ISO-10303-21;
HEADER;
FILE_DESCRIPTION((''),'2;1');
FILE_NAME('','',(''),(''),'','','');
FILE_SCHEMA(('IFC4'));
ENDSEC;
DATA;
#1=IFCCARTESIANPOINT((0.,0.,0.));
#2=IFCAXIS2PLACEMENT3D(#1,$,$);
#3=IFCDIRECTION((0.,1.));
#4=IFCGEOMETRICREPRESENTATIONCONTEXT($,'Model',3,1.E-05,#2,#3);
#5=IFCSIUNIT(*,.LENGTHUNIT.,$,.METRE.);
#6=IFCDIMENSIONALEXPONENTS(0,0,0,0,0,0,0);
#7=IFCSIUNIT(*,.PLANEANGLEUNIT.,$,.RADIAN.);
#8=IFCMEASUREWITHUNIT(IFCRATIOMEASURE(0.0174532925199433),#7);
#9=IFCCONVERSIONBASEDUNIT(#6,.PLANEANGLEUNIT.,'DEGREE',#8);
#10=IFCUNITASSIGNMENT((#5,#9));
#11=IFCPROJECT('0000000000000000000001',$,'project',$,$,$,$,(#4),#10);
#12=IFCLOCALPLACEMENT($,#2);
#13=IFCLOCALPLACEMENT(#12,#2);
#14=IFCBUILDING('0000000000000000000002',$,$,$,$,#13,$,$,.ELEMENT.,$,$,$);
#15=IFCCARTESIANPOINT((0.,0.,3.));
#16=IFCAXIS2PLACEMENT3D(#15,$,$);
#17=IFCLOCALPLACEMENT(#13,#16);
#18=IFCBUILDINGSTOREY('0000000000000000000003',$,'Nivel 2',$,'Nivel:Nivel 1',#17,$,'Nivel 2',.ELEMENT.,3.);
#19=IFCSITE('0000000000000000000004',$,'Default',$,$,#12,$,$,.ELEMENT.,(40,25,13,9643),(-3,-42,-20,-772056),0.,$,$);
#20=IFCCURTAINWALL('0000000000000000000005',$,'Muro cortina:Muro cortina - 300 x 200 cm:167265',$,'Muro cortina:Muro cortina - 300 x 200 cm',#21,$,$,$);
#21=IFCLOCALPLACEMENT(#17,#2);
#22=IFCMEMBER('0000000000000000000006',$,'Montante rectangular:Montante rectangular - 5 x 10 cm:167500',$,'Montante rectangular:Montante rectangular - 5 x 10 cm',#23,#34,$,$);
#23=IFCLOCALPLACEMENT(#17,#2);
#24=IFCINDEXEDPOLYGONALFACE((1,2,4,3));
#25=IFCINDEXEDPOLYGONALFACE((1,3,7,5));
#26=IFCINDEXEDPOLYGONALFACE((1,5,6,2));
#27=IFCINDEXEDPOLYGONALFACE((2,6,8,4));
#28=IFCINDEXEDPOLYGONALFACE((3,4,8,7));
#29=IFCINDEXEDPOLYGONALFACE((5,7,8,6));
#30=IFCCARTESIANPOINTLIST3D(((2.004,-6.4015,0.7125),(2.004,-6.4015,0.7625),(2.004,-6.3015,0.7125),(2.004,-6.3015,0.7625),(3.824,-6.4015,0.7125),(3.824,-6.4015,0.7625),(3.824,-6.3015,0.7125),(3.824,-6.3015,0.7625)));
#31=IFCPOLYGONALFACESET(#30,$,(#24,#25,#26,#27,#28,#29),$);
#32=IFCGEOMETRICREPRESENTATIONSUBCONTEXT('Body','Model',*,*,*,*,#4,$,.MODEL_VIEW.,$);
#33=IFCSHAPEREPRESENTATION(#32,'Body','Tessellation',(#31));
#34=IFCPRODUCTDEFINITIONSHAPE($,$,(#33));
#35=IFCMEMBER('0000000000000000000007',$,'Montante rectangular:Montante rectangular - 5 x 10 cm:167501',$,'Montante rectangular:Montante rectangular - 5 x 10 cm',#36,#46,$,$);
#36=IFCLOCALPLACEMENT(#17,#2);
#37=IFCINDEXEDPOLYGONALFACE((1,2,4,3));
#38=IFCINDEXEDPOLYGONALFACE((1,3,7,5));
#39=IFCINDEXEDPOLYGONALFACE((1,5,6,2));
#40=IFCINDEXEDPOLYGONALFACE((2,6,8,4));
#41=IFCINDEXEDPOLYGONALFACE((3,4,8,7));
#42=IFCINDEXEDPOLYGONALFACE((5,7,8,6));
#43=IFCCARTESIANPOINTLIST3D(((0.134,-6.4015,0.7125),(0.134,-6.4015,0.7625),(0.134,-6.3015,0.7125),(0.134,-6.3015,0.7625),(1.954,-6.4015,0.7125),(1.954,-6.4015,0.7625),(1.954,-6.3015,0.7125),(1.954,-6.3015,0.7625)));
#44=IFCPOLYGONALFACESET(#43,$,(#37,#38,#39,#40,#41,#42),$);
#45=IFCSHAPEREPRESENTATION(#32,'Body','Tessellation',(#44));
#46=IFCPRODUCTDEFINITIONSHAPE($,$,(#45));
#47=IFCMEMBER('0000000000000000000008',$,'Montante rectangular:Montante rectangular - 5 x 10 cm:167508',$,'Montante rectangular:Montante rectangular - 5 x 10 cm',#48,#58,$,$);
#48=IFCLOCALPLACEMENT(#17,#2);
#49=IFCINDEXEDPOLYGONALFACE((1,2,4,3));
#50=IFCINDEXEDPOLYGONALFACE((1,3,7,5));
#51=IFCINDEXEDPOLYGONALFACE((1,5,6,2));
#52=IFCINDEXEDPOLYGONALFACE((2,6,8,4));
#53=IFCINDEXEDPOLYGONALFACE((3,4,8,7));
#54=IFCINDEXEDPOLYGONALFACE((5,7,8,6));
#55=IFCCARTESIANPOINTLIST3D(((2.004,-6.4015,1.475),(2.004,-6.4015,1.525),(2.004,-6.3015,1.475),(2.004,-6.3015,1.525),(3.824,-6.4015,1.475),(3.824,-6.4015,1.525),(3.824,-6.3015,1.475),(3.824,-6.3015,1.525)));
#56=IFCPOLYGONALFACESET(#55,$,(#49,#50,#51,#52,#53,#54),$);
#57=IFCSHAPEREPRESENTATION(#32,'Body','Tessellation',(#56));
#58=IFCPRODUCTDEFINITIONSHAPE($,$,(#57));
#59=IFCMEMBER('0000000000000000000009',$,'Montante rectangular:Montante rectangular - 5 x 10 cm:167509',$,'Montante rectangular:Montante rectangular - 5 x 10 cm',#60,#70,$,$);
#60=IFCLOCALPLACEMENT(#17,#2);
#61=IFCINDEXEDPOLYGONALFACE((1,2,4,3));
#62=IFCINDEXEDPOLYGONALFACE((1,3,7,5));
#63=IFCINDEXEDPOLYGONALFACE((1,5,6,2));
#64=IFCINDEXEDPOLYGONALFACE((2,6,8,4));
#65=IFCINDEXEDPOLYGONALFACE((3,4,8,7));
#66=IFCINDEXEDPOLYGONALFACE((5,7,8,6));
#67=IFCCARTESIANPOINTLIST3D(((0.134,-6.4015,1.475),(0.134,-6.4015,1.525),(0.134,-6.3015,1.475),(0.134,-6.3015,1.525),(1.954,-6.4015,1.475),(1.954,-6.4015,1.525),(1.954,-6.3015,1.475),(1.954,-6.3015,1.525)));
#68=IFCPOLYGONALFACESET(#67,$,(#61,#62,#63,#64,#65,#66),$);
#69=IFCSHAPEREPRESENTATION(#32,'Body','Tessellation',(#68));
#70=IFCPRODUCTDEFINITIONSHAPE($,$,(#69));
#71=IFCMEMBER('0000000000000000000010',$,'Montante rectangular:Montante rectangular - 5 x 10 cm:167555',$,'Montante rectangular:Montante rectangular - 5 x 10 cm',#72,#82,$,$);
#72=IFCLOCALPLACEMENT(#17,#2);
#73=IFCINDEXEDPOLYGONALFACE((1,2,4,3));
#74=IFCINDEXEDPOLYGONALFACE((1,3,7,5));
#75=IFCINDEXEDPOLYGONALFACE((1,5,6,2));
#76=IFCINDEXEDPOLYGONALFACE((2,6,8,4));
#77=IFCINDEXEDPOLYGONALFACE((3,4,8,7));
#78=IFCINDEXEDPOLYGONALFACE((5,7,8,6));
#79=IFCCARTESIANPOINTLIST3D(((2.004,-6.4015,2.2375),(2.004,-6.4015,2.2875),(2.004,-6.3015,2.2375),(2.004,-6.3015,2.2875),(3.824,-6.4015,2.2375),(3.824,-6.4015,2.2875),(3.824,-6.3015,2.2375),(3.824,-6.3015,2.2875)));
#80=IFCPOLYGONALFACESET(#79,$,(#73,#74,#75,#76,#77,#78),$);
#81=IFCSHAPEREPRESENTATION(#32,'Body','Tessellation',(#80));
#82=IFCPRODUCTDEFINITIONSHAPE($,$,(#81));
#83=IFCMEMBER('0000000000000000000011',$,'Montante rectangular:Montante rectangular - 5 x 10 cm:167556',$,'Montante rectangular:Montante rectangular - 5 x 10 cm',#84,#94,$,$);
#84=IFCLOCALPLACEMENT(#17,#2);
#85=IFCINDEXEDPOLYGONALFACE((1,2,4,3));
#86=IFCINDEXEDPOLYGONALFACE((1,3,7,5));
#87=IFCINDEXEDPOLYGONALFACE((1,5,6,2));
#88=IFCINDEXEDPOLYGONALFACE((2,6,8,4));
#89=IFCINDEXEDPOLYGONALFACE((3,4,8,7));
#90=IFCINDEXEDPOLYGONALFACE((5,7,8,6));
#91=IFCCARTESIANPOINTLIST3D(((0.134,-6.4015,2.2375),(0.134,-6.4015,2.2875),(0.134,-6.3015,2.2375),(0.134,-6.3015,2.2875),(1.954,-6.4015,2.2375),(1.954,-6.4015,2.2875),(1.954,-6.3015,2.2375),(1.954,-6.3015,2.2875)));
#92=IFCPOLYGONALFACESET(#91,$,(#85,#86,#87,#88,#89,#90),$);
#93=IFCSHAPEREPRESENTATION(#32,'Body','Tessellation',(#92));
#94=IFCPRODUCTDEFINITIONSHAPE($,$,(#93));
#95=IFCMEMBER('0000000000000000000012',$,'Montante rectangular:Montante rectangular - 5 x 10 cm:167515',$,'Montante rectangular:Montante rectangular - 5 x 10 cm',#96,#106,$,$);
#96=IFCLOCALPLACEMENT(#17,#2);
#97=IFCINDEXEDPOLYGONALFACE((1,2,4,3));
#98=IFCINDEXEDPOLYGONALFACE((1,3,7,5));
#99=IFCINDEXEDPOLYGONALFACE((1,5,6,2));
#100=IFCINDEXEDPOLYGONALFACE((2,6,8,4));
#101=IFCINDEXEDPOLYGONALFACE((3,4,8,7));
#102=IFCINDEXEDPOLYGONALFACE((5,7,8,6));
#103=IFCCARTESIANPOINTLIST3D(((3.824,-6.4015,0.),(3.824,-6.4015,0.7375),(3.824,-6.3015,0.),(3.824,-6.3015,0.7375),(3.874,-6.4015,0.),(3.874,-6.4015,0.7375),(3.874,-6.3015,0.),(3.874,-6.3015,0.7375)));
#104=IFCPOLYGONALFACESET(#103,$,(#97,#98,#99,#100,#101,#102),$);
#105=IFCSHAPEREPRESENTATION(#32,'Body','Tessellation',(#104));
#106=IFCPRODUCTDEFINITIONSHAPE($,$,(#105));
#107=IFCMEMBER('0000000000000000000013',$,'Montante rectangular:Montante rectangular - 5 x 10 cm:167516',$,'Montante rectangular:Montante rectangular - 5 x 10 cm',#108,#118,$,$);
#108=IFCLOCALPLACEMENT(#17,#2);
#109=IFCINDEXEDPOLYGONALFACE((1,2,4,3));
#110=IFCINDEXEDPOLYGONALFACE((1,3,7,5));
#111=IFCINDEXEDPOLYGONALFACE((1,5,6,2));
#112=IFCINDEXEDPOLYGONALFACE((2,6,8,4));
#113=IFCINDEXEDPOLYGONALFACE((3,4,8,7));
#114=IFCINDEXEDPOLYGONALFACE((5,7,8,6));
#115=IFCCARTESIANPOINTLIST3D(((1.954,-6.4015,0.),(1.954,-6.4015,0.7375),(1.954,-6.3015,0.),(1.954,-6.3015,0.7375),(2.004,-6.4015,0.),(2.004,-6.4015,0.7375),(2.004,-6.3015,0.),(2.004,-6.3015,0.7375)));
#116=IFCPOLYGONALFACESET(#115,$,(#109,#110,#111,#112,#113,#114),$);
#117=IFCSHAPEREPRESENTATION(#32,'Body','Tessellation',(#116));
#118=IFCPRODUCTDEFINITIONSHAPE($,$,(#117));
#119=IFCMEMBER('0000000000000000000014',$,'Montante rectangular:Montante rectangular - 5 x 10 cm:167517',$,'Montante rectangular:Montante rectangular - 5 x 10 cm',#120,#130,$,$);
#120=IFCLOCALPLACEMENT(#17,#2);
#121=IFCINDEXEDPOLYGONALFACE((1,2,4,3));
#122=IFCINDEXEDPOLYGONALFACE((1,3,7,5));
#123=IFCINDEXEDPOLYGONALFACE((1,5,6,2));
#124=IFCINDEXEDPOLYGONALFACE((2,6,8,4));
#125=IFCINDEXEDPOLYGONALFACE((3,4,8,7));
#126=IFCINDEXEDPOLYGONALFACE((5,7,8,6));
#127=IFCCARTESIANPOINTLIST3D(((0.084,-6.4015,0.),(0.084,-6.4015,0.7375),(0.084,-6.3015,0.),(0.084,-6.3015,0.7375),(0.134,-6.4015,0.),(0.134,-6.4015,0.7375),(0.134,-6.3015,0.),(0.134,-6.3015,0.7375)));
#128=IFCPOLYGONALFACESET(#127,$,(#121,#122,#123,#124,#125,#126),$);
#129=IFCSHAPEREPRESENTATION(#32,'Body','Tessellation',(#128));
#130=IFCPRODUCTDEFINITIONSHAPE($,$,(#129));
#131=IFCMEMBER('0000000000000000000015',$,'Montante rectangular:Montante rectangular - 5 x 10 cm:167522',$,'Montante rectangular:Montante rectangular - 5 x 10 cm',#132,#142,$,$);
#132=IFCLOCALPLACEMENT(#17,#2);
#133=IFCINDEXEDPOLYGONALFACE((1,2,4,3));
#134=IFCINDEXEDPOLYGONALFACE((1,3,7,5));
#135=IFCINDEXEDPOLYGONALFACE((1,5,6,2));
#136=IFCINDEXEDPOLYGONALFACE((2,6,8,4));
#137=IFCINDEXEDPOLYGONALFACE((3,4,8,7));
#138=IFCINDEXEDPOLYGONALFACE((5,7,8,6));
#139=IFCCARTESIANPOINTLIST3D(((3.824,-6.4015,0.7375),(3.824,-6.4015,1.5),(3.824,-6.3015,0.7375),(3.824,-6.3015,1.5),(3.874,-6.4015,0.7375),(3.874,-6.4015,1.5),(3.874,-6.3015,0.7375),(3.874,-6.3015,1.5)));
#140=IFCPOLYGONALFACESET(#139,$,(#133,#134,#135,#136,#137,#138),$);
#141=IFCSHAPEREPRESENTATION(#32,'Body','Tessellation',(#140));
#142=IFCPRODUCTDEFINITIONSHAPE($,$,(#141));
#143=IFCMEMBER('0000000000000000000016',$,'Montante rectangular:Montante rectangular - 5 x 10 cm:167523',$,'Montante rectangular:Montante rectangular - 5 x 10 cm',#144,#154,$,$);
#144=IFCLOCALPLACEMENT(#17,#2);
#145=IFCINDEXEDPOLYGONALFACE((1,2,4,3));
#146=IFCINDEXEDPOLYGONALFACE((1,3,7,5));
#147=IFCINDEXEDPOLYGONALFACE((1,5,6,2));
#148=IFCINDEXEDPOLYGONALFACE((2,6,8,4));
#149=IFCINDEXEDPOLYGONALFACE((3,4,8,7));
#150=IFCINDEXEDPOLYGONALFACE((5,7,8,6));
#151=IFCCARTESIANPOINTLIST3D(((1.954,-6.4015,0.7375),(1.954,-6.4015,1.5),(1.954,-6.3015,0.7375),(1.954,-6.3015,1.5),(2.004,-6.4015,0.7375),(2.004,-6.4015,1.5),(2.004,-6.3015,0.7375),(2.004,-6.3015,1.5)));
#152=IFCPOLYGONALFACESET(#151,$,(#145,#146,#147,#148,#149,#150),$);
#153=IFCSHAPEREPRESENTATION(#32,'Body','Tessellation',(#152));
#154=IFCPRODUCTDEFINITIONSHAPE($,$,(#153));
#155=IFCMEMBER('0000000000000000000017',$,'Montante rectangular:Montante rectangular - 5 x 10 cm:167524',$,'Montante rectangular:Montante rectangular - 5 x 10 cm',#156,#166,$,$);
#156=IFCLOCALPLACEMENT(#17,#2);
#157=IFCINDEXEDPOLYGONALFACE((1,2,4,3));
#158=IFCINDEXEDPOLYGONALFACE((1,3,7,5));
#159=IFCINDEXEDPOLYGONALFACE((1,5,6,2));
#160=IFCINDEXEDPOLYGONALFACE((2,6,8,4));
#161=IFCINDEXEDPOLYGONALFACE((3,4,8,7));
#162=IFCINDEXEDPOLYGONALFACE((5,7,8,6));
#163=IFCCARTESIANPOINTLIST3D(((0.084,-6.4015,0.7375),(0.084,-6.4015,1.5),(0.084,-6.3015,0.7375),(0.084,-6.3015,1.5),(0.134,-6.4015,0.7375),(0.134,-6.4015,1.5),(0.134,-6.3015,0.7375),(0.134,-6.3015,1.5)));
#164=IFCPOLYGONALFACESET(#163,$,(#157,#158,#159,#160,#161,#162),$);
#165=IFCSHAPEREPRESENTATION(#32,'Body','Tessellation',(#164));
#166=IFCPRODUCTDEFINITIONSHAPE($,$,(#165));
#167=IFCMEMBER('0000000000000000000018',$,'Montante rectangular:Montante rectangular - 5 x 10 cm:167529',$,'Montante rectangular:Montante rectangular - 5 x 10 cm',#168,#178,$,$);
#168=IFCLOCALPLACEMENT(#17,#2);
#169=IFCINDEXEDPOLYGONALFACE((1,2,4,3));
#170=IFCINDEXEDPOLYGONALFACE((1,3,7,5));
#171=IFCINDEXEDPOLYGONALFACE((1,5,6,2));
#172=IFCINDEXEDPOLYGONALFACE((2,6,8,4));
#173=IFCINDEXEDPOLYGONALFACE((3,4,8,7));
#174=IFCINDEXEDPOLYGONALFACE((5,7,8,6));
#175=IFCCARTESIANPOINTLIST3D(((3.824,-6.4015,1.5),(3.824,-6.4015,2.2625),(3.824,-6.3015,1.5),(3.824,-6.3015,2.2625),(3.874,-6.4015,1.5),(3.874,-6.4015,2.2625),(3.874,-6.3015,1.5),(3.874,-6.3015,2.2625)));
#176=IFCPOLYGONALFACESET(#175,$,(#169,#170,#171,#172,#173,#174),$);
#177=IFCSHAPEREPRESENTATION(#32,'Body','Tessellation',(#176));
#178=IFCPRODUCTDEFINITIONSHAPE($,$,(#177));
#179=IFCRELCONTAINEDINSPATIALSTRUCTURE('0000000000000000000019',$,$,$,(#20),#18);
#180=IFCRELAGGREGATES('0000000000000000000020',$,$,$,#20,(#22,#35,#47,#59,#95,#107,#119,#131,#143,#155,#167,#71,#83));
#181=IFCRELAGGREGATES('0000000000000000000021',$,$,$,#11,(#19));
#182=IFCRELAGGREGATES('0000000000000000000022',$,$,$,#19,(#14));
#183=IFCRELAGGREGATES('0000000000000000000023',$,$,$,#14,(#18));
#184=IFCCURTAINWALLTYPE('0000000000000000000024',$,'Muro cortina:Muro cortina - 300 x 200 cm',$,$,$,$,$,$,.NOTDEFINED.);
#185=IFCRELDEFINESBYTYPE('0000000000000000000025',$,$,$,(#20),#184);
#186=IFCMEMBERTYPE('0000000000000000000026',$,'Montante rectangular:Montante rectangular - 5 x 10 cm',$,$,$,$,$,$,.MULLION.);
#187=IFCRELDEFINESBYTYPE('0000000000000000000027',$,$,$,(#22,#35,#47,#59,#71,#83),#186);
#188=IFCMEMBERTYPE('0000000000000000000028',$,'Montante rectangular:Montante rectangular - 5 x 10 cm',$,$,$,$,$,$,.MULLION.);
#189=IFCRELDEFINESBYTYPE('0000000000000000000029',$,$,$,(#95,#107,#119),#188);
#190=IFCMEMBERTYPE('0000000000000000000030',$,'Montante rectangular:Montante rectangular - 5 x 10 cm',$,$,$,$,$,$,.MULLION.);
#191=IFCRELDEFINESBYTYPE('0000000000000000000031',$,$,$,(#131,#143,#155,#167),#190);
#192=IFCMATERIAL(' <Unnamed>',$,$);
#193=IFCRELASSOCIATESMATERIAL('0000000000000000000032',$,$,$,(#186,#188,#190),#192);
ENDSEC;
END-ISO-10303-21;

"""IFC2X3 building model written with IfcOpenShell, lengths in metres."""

from ifc_helpers import new_model, entity, si_unit, converted_unit, direction, frame, origin, origin_2d_with_axis, place, context, subcontext, project, spatial, rectangle, extrude, source, transform, mapped, material, type_object, type_shapes, element, aggregate, save


model = new_model("IFC2X3")

# Units and contexts
model_context = context("Model", 3, precision=1e-05, world=origin(), true_north=direction((0.0, 1.0)))
body_context = subcontext(model_context, "Body", "Model", "MODEL_VIEW")
ifc_project = project(units=[si_unit("LENGTHUNIT", "METRE"), converted_unit("PLANEANGLEUNIT", "DEGREE", entity("IfcRatioMeasure", 0.0174532925199433), si_unit("PLANEANGLEUNIT", "RADIAN"), dimensions=[0, 0, 0, 0, 0, 0, 0])], contexts=[model_context])

# Site, building, storey
site_placement = place(None, origin())
site = spatial("IfcSite", under=ifc_project, at=site_placement, Name="Default", CompositionType="ELEMENT", RefLatitude=(40, 25, 13, 9643), RefLongitude=(-3, -42, -20, -772056), RefElevation=0.0)
building_placement = place(site_placement, origin())
building = spatial("IfcBuilding", under=site, at=building_placement, CompositionType="ELEMENT")
storey_placement = place(building_placement, frame((0.0, 0.0, 3.0)))
storey = spatial("IfcBuildingStorey", under=building, at=storey_placement, Name="Nivel 2", ObjectType="Nivel:Nivel 1", LongName="Nivel 2", CompositionType="ELEMENT", Elevation=3.0)

# Curtain wall, members
curtain_wall_type = type_object("IfcCurtainWallType", Name="Muro cortina:Muro cortina - 300 x 200 cm", PredefinedType="NOTDEFINED")
curtain_wall_placement = place(storey_placement, frame((0.0, 0.0, -3.0)))
curtain_wall = element("IfcCurtainWall", 1, at=curtain_wall_placement, inside=storey, type_object=curtain_wall_type, Name="Muro cortina:Muro cortina - 300 x 200 cm:167265", ObjectType="Muro cortina:Muro cortina - 300 x 200 cm")
ifc_material_1 = material(Name=" <Unnamed>")
member_type_1 = type_object("IfcMemberType", Name="Montante rectangular:Montante rectangular - 5 x 10 cm", PredefinedType="MULLION", material=ifc_material_1)
shared_shape_1 = source(origin(), body_context, "Body", "SweptSolid", [
    extrude(rectangle(XDim=0.1, YDim=0.05, at=origin_2d_with_axis()), frame((0.0, 0.0, -1.82), z_axis=(0.0, 0.0, 1.0), x_axis=(0.0, -1.0, 0.0)), (0.0, 0.0, 1.0), 1.82),
])
type_shapes(member_type_1, [shared_shape_1])
member_1_placement = place(storey_placement, frame((2.004, -6.3515, 0.7375), z_axis=(-1.0, 0.0, 0.0), x_axis=(0.0, 0.0, 1.0)))
member_1 = element("IfcMember", 2, at=member_1_placement, type_object=member_type_1, Name="Montante rectangular:Montante rectangular - 5 x 10 cm:167500", ObjectType="Montante rectangular:Montante rectangular - 5 x 10 cm", context=body_context, shape_type="MappedRepresentation", body=[
    mapped(shared_shape_1, transform((0.0, 0.0, 0.0), scale=1.0)),
])
member_2_placement = place(storey_placement, frame((0.134, -6.3515, 0.7375), z_axis=(-1.0, 0.0, 0.0), x_axis=(0.0, 0.0, 1.0)))
member_2 = element("IfcMember", 3, at=member_2_placement, type_object=member_type_1, Name="Montante rectangular:Montante rectangular - 5 x 10 cm:167501", ObjectType="Montante rectangular:Montante rectangular - 5 x 10 cm", context=body_context, shape_type="MappedRepresentation", body=[
    mapped(shared_shape_1, transform((0.0, 0.0, 0.0), scale=1.0)),
])
member_3_placement = place(storey_placement, frame((2.004, -6.3515, 1.5), z_axis=(-1.0, 0.0, 0.0), x_axis=(0.0, 0.0, 1.0)))
member_3 = element("IfcMember", 4, at=member_3_placement, type_object=member_type_1, Name="Montante rectangular:Montante rectangular - 5 x 10 cm:167508", ObjectType="Montante rectangular:Montante rectangular - 5 x 10 cm", context=body_context, shape_type="MappedRepresentation", body=[
    mapped(shared_shape_1, transform((0.0, 0.0, 0.0), scale=1.0)),
])
member_4_placement = place(storey_placement, frame((0.134, -6.3515, 1.5), z_axis=(-1.0, 0.0, 0.0), x_axis=(0.0, 0.0, 1.0)))
member_4 = element("IfcMember", 5, at=member_4_placement, type_object=member_type_1, Name="Montante rectangular:Montante rectangular - 5 x 10 cm:167509", ObjectType="Montante rectangular:Montante rectangular - 5 x 10 cm", context=body_context, shape_type="MappedRepresentation", body=[
    mapped(shared_shape_1, transform((0.0, 0.0, 0.0), scale=1.0)),
])
member_5_placement = place(storey_placement, frame((2.004, -6.3515, 2.2625), z_axis=(-1.0, 0.0, 0.0), x_axis=(0.0, 0.0, 1.0)))
member_5 = element("IfcMember", 6, at=member_5_placement, type_object=member_type_1, Name="Montante rectangular:Montante rectangular - 5 x 10 cm:167555", ObjectType="Montante rectangular:Montante rectangular - 5 x 10 cm", context=body_context, shape_type="MappedRepresentation", body=[
    mapped(shared_shape_1, transform((0.0, 0.0, 0.0), scale=1.0)),
])
member_6_placement = place(storey_placement, frame((0.134, -6.3515, 2.2625), z_axis=(-1.0, 0.0, 0.0), x_axis=(0.0, 0.0, 1.0)))
member_6 = element("IfcMember", 7, at=member_6_placement, type_object=member_type_1, Name="Montante rectangular:Montante rectangular - 5 x 10 cm:167556", ObjectType="Montante rectangular:Montante rectangular - 5 x 10 cm", context=body_context, shape_type="MappedRepresentation", body=[
    mapped(shared_shape_1, transform((0.0, 0.0, 0.0), scale=1.0)),
])
member_type_2 = type_object("IfcMemberType", Name="Montante rectangular:Montante rectangular - 5 x 10 cm", PredefinedType="MULLION", material=ifc_material_1)
shared_shape_2 = source(origin(), body_context, "Body", "SweptSolid", [
    extrude(rectangle(XDim=0.1, YDim=0.05, at=origin_2d_with_axis()), frame((0.0, 0.0, -0.7375), z_axis=(0.0, 0.0, 1.0), x_axis=(0.0, -1.0, 0.0)), (0.0, 0.0, 1.0), 0.7375),
])
type_shapes(member_type_2, [shared_shape_2])
member_7_placement = place(storey_placement, frame((3.849, -6.3515, 0.0), z_axis=(0.0, 0.0, -1.0), x_axis=(-1.0, 0.0, 0.0)))
member_7 = element("IfcMember", 8, at=member_7_placement, type_object=member_type_2, Name="Montante rectangular:Montante rectangular - 5 x 10 cm:167515", ObjectType="Montante rectangular:Montante rectangular - 5 x 10 cm", context=body_context, shape_type="MappedRepresentation", body=[
    mapped(shared_shape_2, transform((0.0, 0.0, 0.0), scale=1.0)),
])
member_8_placement = place(storey_placement, frame((1.979, -6.3515, 0.0), z_axis=(0.0, 0.0, -1.0), x_axis=(-1.0, 0.0, 0.0)))
member_8 = element("IfcMember", 9, at=member_8_placement, type_object=member_type_2, Name="Montante rectangular:Montante rectangular - 5 x 10 cm:167516", ObjectType="Montante rectangular:Montante rectangular - 5 x 10 cm", context=body_context, shape_type="MappedRepresentation", body=[
    mapped(shared_shape_2, transform((0.0, 0.0, 0.0), scale=1.0)),
])
member_9_placement = place(storey_placement, frame((0.109, -6.3515, 0.0), z_axis=(0.0, 0.0, -1.0), x_axis=(-1.0, 0.0, 0.0)))
member_9 = element("IfcMember", 10, at=member_9_placement, type_object=member_type_2, Name="Montante rectangular:Montante rectangular - 5 x 10 cm:167517", ObjectType="Montante rectangular:Montante rectangular - 5 x 10 cm", context=body_context, shape_type="MappedRepresentation", body=[
    mapped(shared_shape_2, transform((0.0, 0.0, 0.0), scale=1.0)),
])
member_type_3 = type_object("IfcMemberType", Name="Montante rectangular:Montante rectangular - 5 x 10 cm", PredefinedType="MULLION", material=ifc_material_1)
shared_shape_3 = source(origin(), body_context, "Body", "SweptSolid", [
    extrude(rectangle(XDim=0.1, YDim=0.05, at=origin_2d_with_axis()), frame((0.0, 0.0, -0.7625), z_axis=(0.0, 0.0, 1.0), x_axis=(0.0, -1.0, 0.0)), (0.0, 0.0, 1.0), 0.7625),
])
type_shapes(member_type_3, [shared_shape_3])
member_10_placement = place(storey_placement, frame((3.849, -6.3515, 0.7375), z_axis=(0.0, 0.0, -1.0), x_axis=(-1.0, 0.0, 0.0)))
member_10 = element("IfcMember", 11, at=member_10_placement, type_object=member_type_3, Name="Montante rectangular:Montante rectangular - 5 x 10 cm:167522", ObjectType="Montante rectangular:Montante rectangular - 5 x 10 cm", context=body_context, shape_type="MappedRepresentation", body=[
    mapped(shared_shape_3, transform((0.0, 0.0, 0.0), scale=1.0)),
])
member_11_placement = place(storey_placement, frame((1.979, -6.3515, 0.7375), z_axis=(0.0, 0.0, -1.0), x_axis=(-1.0, 0.0, 0.0)))
member_11 = element("IfcMember", 12, at=member_11_placement, type_object=member_type_3, Name="Montante rectangular:Montante rectangular - 5 x 10 cm:167523", ObjectType="Montante rectangular:Montante rectangular - 5 x 10 cm", context=body_context, shape_type="MappedRepresentation", body=[
    mapped(shared_shape_3, transform((0.0, 0.0, 0.0), scale=1.0)),
])
member_12_placement = place(storey_placement, frame((0.109, -6.3515, 0.7375), z_axis=(0.0, 0.0, -1.0), x_axis=(-1.0, 0.0, 0.0)))
member_12 = element("IfcMember", 13, at=member_12_placement, type_object=member_type_3, Name="Montante rectangular:Montante rectangular - 5 x 10 cm:167524", ObjectType="Montante rectangular:Montante rectangular - 5 x 10 cm", context=body_context, shape_type="MappedRepresentation", body=[
    mapped(shared_shape_3, transform((0.0, 0.0, 0.0), scale=1.0)),
])
member_13_placement = place(storey_placement, frame((3.849, -6.3515, 1.5), z_axis=(0.0, 0.0, -1.0), x_axis=(-1.0, 0.0, 0.0)))
member_13 = element("IfcMember", 14, at=member_13_placement, type_object=member_type_3, Name="Montante rectangular:Montante rectangular - 5 x 10 cm:167529", ObjectType="Montante rectangular:Montante rectangular - 5 x 10 cm", context=body_context, shape_type="MappedRepresentation", body=[
    mapped(shared_shape_3, transform((0.0, 0.0, 0.0), scale=1.0)),
])
aggregate(curtain_wall, [member_1, member_2, member_3, member_4, member_7, member_8, member_9, member_10, member_11, member_12, member_13, member_5, member_6])

save(model, "model.ifc")
